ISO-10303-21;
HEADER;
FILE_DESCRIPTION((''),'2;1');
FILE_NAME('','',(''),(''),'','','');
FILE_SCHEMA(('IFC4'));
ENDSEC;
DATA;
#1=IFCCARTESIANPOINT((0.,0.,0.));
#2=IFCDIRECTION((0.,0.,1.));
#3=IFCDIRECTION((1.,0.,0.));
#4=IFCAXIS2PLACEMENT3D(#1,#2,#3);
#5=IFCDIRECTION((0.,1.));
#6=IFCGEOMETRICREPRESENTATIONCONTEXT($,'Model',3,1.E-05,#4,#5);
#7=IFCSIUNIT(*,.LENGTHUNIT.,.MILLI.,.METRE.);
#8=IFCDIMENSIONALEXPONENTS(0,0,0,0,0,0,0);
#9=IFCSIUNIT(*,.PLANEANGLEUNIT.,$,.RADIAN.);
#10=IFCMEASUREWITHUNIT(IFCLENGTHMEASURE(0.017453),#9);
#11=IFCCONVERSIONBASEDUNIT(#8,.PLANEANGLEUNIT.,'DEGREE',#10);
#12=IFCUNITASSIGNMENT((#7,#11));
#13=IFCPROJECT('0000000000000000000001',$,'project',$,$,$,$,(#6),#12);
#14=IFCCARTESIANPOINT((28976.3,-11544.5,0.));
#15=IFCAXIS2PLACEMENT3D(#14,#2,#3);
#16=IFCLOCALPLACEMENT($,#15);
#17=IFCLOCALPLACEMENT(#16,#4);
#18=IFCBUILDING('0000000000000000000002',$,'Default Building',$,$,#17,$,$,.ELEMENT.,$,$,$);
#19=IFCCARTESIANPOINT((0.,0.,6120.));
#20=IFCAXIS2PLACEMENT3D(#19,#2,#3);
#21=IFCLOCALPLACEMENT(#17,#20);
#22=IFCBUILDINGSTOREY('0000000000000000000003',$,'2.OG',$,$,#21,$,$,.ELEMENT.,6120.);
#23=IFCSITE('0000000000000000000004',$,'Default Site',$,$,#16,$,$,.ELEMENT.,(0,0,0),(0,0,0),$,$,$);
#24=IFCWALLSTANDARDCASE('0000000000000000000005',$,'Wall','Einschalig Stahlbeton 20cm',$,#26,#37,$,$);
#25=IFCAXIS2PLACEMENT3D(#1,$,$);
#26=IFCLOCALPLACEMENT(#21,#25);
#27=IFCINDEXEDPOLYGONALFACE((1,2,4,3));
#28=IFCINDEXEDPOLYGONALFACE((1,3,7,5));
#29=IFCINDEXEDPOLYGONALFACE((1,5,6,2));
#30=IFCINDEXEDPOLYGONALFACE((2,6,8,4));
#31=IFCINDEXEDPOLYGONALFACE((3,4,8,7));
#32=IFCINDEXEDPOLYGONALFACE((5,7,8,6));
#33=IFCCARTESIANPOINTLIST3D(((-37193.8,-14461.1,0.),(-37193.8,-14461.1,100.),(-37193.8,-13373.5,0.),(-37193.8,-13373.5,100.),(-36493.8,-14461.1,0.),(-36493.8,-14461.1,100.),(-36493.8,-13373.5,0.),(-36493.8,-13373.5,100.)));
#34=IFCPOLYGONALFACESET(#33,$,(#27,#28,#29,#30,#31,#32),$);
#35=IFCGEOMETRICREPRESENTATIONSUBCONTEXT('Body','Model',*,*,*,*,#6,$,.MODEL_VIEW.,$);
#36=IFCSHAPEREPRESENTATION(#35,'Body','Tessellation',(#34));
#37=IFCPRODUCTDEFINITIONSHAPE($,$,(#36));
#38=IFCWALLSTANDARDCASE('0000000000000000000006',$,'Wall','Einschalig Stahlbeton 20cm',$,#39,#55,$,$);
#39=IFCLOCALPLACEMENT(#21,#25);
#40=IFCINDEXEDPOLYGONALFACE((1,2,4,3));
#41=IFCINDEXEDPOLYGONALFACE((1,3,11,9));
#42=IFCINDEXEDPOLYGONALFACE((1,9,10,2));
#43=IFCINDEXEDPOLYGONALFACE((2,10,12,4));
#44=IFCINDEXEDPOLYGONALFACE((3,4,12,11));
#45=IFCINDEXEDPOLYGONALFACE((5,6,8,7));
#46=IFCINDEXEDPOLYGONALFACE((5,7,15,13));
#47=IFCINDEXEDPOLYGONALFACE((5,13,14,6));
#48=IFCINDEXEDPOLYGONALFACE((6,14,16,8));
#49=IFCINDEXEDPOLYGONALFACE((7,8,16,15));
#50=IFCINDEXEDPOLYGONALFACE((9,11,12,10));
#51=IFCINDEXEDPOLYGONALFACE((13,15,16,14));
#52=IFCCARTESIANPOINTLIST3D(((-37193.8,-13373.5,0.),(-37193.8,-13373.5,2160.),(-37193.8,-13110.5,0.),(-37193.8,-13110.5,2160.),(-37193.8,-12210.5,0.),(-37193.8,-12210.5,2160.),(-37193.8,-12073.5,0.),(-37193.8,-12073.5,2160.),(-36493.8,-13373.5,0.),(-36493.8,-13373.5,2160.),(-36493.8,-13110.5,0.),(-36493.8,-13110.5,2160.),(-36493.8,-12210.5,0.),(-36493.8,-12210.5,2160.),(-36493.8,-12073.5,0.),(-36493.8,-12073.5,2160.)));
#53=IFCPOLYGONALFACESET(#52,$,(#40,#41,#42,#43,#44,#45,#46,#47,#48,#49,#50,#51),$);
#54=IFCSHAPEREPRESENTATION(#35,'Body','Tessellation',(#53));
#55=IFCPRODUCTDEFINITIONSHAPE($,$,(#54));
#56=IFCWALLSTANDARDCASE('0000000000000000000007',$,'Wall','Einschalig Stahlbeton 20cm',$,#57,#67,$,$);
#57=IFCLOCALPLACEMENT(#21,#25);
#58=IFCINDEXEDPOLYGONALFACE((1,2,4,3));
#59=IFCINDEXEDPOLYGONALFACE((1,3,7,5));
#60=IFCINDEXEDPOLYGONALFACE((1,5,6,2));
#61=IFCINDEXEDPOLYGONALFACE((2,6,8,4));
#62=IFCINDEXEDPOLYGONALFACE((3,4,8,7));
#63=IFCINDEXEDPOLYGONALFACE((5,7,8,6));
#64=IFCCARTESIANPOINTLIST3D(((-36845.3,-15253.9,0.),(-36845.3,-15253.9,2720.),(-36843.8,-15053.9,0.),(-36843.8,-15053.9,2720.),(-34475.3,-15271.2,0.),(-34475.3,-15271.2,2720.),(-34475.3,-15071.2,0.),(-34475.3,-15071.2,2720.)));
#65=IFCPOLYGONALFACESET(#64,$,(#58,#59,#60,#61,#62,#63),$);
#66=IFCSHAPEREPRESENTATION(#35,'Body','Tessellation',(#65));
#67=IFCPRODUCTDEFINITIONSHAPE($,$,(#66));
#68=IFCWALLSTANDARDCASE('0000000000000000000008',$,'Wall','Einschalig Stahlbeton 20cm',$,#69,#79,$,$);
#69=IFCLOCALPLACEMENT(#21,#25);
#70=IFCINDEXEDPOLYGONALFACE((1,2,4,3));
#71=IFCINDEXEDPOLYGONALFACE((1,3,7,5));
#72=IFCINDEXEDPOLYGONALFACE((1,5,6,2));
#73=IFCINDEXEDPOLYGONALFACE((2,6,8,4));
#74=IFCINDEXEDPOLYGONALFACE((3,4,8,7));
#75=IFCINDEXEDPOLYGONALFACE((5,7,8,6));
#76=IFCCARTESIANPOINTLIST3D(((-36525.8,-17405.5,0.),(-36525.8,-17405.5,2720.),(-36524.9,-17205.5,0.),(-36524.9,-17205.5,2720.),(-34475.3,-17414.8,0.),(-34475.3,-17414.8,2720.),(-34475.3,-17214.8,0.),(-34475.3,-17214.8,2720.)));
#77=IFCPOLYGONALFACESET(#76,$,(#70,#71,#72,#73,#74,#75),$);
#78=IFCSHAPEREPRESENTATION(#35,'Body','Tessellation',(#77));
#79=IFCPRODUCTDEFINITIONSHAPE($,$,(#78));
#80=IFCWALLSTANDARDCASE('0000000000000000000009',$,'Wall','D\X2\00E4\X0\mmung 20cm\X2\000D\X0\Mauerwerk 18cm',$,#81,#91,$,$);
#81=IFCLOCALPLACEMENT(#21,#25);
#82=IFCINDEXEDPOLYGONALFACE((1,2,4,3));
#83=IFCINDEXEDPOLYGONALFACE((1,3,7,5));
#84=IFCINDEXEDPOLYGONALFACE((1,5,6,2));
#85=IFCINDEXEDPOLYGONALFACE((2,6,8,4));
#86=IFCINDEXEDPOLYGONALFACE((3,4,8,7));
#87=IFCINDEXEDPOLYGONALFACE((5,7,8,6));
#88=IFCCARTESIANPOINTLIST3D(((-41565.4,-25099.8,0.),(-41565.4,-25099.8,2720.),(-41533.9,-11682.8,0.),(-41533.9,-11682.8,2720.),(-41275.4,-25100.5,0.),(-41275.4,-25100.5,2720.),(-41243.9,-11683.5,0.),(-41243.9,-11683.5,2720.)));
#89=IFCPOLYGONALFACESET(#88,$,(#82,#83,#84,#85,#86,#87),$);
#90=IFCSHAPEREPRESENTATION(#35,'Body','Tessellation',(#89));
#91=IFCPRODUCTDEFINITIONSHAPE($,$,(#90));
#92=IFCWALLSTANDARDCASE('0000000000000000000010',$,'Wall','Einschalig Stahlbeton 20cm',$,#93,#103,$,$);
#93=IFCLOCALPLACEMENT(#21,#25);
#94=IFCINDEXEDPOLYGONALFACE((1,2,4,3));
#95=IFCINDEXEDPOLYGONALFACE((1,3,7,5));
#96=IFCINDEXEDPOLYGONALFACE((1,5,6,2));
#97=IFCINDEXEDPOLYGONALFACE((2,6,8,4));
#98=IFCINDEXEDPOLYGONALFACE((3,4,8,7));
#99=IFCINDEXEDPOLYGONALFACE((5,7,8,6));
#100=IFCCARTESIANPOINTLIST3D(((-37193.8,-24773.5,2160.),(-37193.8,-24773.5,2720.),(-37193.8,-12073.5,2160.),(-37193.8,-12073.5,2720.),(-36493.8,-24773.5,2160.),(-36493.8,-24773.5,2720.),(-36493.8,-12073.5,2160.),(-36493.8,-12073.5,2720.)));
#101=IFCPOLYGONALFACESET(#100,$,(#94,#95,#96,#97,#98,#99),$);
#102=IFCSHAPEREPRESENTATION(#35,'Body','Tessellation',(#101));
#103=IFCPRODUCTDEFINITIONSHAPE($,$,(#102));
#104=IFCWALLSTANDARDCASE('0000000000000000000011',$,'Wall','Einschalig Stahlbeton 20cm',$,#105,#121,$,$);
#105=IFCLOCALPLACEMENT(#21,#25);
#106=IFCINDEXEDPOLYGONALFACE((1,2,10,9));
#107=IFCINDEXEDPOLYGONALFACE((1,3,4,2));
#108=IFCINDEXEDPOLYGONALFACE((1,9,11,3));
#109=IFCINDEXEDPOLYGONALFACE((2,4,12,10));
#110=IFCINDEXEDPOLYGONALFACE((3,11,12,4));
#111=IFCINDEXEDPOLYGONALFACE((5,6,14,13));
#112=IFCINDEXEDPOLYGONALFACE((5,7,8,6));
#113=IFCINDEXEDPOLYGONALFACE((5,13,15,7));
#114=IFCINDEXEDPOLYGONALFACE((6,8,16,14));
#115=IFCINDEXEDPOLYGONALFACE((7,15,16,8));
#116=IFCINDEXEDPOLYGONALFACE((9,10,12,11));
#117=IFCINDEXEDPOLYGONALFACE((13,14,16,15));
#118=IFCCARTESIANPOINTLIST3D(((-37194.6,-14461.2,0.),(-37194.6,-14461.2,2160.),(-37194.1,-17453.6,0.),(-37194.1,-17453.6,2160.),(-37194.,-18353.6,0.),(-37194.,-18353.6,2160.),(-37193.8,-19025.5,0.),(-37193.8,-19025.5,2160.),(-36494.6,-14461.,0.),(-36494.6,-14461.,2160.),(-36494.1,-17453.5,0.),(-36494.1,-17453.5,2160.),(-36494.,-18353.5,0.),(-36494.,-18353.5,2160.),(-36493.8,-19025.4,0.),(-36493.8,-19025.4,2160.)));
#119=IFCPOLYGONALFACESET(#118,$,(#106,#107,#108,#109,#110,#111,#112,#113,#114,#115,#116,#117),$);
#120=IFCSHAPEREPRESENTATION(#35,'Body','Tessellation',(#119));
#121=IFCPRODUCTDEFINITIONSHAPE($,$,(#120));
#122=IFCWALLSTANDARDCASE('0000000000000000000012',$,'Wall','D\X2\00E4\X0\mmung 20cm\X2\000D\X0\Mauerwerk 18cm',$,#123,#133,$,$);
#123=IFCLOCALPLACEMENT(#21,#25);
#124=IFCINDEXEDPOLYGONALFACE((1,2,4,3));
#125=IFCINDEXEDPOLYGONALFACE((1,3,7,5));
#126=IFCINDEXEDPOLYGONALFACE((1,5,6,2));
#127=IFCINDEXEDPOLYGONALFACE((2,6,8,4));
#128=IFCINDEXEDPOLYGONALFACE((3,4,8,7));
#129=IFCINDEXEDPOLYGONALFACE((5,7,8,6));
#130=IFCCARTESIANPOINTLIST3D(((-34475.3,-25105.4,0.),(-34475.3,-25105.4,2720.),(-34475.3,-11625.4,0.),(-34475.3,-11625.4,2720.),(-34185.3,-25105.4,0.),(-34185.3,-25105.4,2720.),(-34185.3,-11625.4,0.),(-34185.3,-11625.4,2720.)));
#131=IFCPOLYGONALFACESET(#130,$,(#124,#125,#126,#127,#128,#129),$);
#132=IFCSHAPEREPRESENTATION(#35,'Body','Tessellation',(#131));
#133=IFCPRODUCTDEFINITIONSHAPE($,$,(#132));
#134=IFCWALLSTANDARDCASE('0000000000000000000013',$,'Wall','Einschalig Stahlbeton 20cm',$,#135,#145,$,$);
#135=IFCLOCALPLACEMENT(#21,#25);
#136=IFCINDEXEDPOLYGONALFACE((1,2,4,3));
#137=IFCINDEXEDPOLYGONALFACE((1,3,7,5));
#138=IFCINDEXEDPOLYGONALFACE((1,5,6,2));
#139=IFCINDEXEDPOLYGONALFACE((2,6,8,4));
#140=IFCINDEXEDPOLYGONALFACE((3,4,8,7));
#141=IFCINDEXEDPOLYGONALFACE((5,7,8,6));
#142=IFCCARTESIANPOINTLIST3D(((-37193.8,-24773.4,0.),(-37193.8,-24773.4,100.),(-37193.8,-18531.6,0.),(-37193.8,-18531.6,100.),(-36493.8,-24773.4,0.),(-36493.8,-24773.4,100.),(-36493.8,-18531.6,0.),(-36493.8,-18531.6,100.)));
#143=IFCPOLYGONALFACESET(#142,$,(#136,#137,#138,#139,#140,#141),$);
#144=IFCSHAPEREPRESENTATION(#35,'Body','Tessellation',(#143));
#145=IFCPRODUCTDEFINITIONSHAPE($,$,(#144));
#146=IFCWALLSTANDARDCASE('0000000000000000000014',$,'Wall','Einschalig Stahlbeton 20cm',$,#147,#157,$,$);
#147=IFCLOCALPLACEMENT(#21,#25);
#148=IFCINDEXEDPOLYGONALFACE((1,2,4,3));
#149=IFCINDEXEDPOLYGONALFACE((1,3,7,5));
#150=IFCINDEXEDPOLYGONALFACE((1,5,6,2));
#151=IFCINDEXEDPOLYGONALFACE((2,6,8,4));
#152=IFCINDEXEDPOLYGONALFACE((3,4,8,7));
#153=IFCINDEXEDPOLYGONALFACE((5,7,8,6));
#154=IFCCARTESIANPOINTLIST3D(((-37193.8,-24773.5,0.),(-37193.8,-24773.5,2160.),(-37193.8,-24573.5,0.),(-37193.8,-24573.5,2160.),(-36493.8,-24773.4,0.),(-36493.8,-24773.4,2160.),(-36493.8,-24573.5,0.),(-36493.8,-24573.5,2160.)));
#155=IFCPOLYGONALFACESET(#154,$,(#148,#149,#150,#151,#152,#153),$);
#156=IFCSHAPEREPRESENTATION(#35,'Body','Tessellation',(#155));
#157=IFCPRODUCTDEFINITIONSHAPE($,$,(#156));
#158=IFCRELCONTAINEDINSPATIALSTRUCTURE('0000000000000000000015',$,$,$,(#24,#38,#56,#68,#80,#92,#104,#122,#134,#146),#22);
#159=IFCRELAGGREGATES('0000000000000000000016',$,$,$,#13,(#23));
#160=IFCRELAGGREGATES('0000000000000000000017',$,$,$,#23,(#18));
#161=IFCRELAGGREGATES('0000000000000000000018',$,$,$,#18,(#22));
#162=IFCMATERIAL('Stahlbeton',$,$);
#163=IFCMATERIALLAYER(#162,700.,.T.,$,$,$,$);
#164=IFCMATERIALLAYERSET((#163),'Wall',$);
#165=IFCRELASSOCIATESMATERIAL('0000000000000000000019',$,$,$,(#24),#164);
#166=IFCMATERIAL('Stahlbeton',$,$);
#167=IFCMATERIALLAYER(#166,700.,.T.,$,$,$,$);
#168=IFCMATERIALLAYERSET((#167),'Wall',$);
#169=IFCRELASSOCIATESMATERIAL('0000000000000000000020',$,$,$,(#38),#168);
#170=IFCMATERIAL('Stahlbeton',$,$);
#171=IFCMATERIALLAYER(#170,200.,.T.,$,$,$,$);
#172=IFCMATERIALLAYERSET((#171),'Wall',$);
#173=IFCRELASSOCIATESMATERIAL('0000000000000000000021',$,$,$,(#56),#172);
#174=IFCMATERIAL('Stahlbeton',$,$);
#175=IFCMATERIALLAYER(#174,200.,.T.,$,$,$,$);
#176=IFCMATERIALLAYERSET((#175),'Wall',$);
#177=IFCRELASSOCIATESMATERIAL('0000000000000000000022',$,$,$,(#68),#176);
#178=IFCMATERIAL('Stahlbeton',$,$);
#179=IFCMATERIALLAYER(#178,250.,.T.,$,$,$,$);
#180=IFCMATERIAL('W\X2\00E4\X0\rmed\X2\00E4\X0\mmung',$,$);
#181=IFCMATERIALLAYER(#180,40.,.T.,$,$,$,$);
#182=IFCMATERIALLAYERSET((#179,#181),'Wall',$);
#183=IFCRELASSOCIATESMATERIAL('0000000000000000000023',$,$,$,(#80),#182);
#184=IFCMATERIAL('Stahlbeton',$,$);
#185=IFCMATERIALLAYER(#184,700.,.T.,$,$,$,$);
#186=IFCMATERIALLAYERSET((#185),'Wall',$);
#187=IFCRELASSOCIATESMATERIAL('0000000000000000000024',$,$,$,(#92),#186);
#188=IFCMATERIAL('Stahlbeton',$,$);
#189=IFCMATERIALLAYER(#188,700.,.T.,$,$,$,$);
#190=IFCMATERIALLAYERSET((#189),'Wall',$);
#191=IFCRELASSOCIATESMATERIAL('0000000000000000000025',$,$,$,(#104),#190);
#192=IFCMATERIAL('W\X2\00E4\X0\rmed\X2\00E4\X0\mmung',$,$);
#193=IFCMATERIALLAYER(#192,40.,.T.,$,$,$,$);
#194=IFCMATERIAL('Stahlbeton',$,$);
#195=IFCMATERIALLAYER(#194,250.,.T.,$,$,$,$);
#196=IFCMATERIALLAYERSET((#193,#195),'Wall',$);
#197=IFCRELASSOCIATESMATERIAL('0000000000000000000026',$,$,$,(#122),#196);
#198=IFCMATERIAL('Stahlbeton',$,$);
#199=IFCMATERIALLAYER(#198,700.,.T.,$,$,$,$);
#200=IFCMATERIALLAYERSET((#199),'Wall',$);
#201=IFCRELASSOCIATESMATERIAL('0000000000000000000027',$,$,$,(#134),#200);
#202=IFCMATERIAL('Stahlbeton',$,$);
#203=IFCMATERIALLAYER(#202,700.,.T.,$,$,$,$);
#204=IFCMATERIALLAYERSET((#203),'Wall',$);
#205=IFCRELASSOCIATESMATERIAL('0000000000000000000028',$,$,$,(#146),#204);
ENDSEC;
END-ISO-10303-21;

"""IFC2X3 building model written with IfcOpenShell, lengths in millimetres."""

from ifc_helpers import new_model, entity, si_unit, converted_unit, direction, frame, origin_with_axes, place, context, subcontext, project, spatial, polyline, outline, extrude, material, layer, layer_set, layer_usage, element, save


model = new_model("IFC2X3")

# Units and contexts
model_context = context("Model", 3, precision=1e-05, world=origin_with_axes(), true_north=direction((0.0, 1.0)))
body_context = subcontext(model_context, "Body", "Model", "MODEL_VIEW")
ifc_project = project(units=[si_unit("LENGTHUNIT", "METRE", prefix="MILLI"), converted_unit("PLANEANGLEUNIT", "DEGREE", entity("IfcLengthMeasure", 0.017453), si_unit("PLANEANGLEUNIT", "RADIAN"), dimensions=[0, 0, 0, 0, 0, 0, 0])], contexts=[model_context])

# Site, building, storey
site_placement = place(None, frame((28976.3, -11544.5, 0.0), z_axis=(0.0, 0.0, 1.0), x_axis=(1.0, 0.0, 0.0)))
site = spatial("IfcSite", under=ifc_project, at=site_placement, Name="Default Site", CompositionType="ELEMENT", RefLatitude=(0, 0, 0), RefLongitude=(0, 0, 0))
building_placement = place(site_placement, origin_with_axes())
building = spatial("IfcBuilding", under=site, at=building_placement, Name="Default Building", CompositionType="ELEMENT")
storey_placement = place(building_placement, frame((0.0, 0.0, 6120.0), z_axis=(0.0, 0.0, 1.0), x_axis=(1.0, 0.0, 0.0)))
storey = spatial("IfcBuildingStorey", under=building, at=storey_placement, Name="2.OG", CompositionType="ELEMENT", Elevation=6120.0)

# Wall
ifc_material_1 = material(Name="Stahlbeton")
ifc_layer_1 = layer(ifc_material_1, 700.0, ventilated=True)
ifc_layer_set_1 = layer_set([ifc_layer_1], Name="Wall")
ifc_layer_usage_1 = layer_usage(ifc_layer_set_1, "AXIS2", "POSITIVE", -350.0)
wall_1_placement = place(storey_placement, frame((-36843.8, -13373.5, 0.0), z_axis=(0.0, 0.0, 1.0), x_axis=(0.0, -1.0, 0.0)))
element("IfcWallStandardCase", 1, at=wall_1_placement, inside=storey, material=ifc_layer_usage_1, Name="Wall", Description="Einschalig Stahlbeton 20cm", context=body_context, shape_type="SweptSolid", body=[
    extrude(outline(polyline([(0.0, -350.0), (0.0, 350.0), (1087.7, 350.0), (1087.7, -350.0), (0.0, -350.0)])), origin_with_axes(), (0.0, 0.0, 1.0), 100.0),
])

# Wall, opening
ifc_material_2 = material(Name="Stahlbeton")
ifc_layer_2 = layer(ifc_material_2, 700.0, ventilated=True)
ifc_layer_set_2 = layer_set([ifc_layer_2], Name="Wall")
ifc_layer_usage_2 = layer_usage(ifc_layer_set_2, "AXIS2", "POSITIVE", -350.0)
wall_2_placement = place(storey_placement, frame((-36843.8, -13373.5, 0.0), z_axis=(0.0, 0.0, 1.0), x_axis=(0.0, 1.0, 0.0)))
wall_2 = element("IfcWallStandardCase", 2, at=wall_2_placement, inside=storey, material=ifc_layer_usage_2, Name="Wall", Description="Einschalig Stahlbeton 20cm", context=body_context, shape_type="SweptSolid", body=[
    extrude(outline(polyline([(0.0, -350.0), (0.0, 350.0), (1300.0, 350.0), (1300.0, -350.0), (0.0, -350.0)])), origin_with_axes(), (0.0, 0.0, 1.0), 2160.0),
])
opening_1_placement = place(wall_2_placement, frame((1163.0, 0.0, 0.0), z_axis=(0.0, -1.0, 0.0), x_axis=(0.0, 0.0, 1.0)))
element("IfcOpeningElement", 3, at=opening_1_placement, cuts=wall_2, context=body_context, shape_type="SweptSolid", body=[
    extrude(outline(polyline([(0.0, 0.0), (2160.0, 0.0), (2160.0, 900.0), (0.0, 900.0), (0.0, 0.0), (0.0, 0.0)])), frame((0.0, 0.0, 700.0), z_axis=(0.0, 0.0, 1.0), x_axis=(1.0, 0.0, 0.0)), (0.0, 0.0, -1.0), 1400.0),
])

# Walls
ifc_material_3 = material(Name="Stahlbeton")
ifc_layer_3 = layer(ifc_material_3, 200.0, ventilated=True)
ifc_layer_set_3 = layer_set([ifc_layer_3], Name="Wall")
ifc_layer_usage_3 = layer_usage(ifc_layer_set_3, "AXIS2", "POSITIVE", -100.0)
wall_3_placement = place(storey_placement, frame((-36844.5, -15153.9, 0.0), z_axis=(0.0, 0.0, 1.0), x_axis=(0.999973, -0.007317, 0.0)))
element("IfcWallStandardCase", 4, at=wall_3_placement, inside=storey, material=ifc_layer_usage_3, Name="Wall", Description="Einschalig Stahlbeton 20cm", context=body_context, shape_type="SweptSolid", body=[
    extrude(outline(polyline([(2370.0, -100.0), (2368.5, 100.0), (0.0, 100.0), (0.0, -100.0), (2370.0, -100.0)])), origin_with_axes(), (0.0, 0.0, 1.0), 2720.0),
])
ifc_material_4 = material(Name="Stahlbeton")
ifc_layer_4 = layer(ifc_material_4, 200.0, ventilated=True)
ifc_layer_set_4 = layer_set([ifc_layer_4], Name="Wall")
ifc_layer_usage_4 = layer_usage(ifc_layer_set_4, "AXIS2", "POSITIVE", -100.0)
wall_4_placement = place(storey_placement, frame((-36525.4, -17305.5, 0.0), z_axis=(0.0, 0.0, 1.0), x_axis=(0.99999, -0.004536, 0.0)))
element("IfcWallStandardCase", 5, at=wall_4_placement, inside=storey, material=ifc_layer_usage_4, Name="Wall", Description="Einschalig Stahlbeton 20cm", context=body_context, shape_type="SweptSolid", body=[
    extrude(outline(polyline([(2050.5, -100.0), (2049.6, 100.0), (0.0, 100.0), (0.0, -100.0), (2050.5, -100.0)])), origin_with_axes(), (0.0, 0.0, 1.0), 2720.0),
])
ifc_material_5 = material(Name="Stahlbeton")
ifc_layer_5 = layer(ifc_material_5, 250.0, ventilated=True)
ifc_material_6 = material(Name="Wärmedämmung")
ifc_layer_6 = layer(ifc_material_6, 40.0, ventilated=True)
ifc_layer_set_5 = layer_set([ifc_layer_5, ifc_layer_6], Name="Wall")
ifc_layer_usage_5 = layer_usage(ifc_layer_set_5, "AXIS2", "POSITIVE", -145.0)
wall_5_placement = place(storey_placement, frame((-41420.4, -25100.1, 0.0), z_axis=(0.0, 0.0, 1.0), x_axis=(0.002348, 0.999997, 0.0)))
element("IfcWallStandardCase", 6, at=wall_5_placement, inside=storey, material=ifc_layer_usage_5, Name="Wall", Description="Dämmung 20cm\rMauerwerk 18cm", context=body_context, shape_type="SweptSolid", body=[
    extrude(outline(polyline([(0.0, -145.0), (0.0, 145.0), (13417.0, 145.0), (13417.0, -145.0), (0.0, -145.0)])), origin_with_axes(), (0.0, 0.0, 1.0), 2720.0),
])

# Walls, openings
ifc_material_7 = material(Name="Stahlbeton")
ifc_layer_7 = layer(ifc_material_7, 700.0, ventilated=True)
ifc_layer_set_6 = layer_set([ifc_layer_7], Name="Wall")
ifc_layer_usage_6 = layer_usage(ifc_layer_set_6, "AXIS2", "POSITIVE", -350.0)
wall_6_placement = place(storey_placement, frame((-36843.8, -12073.5, 2160.0), z_axis=(0.0, 0.0, 1.0), x_axis=(0.0, -1.0, 0.0)))
wall_6 = element("IfcWallStandardCase", 7, at=wall_6_placement, inside=storey, material=ifc_layer_usage_6, Name="Wall", Description="Einschalig Stahlbeton 20cm", context=body_context, shape_type="SweptSolid", body=[
    extrude(outline(polyline([(0.0, -350.0), (0.0, 350.0), (12700.0, 350.0), (12700.0, -350.0), (0.0, -350.0)])), origin_with_axes(), (0.0, 0.0, 1.0), 560.0),
])
opening_2_placement = place(wall_6_placement, frame((4232.1, 0.0, -2160.0), z_axis=(0.0, 1.0, 0.0), x_axis=(0.0, 0.0, 1.0)))
element("IfcOpeningElement", 8, at=opening_2_placement, cuts=wall_6, context=body_context, shape_type="SweptSolid", body=[
    extrude(outline(polyline([(0.0, 0.0), (2160.0, 0.0), (2160.0, 900.0), (0.0, 900.0), (0.0, 0.0), (0.0, 0.0)])), frame((0.0, 0.0, 700.0), z_axis=(0.0, 0.0, 1.0), x_axis=(1.0, 0.0, 0.0)), (0.0, 0.0, -1.0), 1400.0),
])
ifc_material_8 = material(Name="Stahlbeton")
ifc_layer_8 = layer(ifc_material_8, 700.0, ventilated=True)
ifc_layer_set_7 = layer_set([ifc_layer_8], Name="Wall")
ifc_layer_usage_7 = layer_usage(ifc_layer_set_7, "AXIS2", "POSITIVE", -350.0)
wall_7_placement = place(storey_placement, frame((-36843.8, -19025.4, 0.0), z_axis=(0.0, 0.0, 1.0), x_axis=(-0.000176, 1.0, 0.0)))
wall_7 = element("IfcWallStandardCase", 9, at=wall_7_placement, inside=storey, material=ifc_layer_usage_7, Name="Wall", Description="Einschalig Stahlbeton 20cm", context=body_context, shape_type="SweptSolid", body=[
    extrude(outline(polyline([(0.0, -350.0), (0.0, 350.0), (4564.3, 350.0), (4564.3, -350.0), (0.0, -350.0)])), origin_with_axes(), (0.0, 0.0, 1.0), 2160.0),
])
opening_3_placement = place(wall_7_placement, frame((671.9, 0.0, 0.0), z_axis=(0.0, 1.0, 0.0), x_axis=(0.0, 0.0, 1.0)))
element("IfcOpeningElement", 10, at=opening_3_placement, cuts=wall_7, context=body_context, shape_type="SweptSolid", body=[
    extrude(outline(polyline([(0.0, 0.0), (2160.0, 0.0), (2160.0, 900.0), (0.0, 900.0), (0.0, 0.0), (0.0, 0.0)])), frame((0.0, 0.0, 700.0), z_axis=(0.0, 0.0, 1.0), x_axis=(1.0, 0.0, 0.0)), (0.0, 0.0, -1.0), 1400.0),
])

# Walls
ifc_material_9 = material(Name="Wärmedämmung")
ifc_layer_9 = layer(ifc_material_9, 40.0, ventilated=True)
ifc_material_10 = material(Name="Stahlbeton")
ifc_layer_10 = layer(ifc_material_10, 250.0, ventilated=True)
ifc_layer_set_8 = layer_set([ifc_layer_9, ifc_layer_10], Name="Wall")
ifc_layer_usage_8 = layer_usage(ifc_layer_set_8, "AXIS2", "POSITIVE", -145.0)
wall_8_placement = place(storey_placement, frame((-34330.3, -11625.4, 0.0), z_axis=(0.0, 0.0, 1.0), x_axis=(0.0, -1.0, 0.0)))
element("IfcWallStandardCase", 11, at=wall_8_placement, inside=storey, material=ifc_layer_usage_8, Name="Wall", Description="Dämmung 20cm\rMauerwerk 18cm", context=body_context, shape_type="SweptSolid", body=[
    extrude(outline(polyline([(0.0, -145.0), (0.0, 145.0), (13480.0, 145.0), (13480.0, -145.0), (0.0, -145.0)])), origin_with_axes(), (0.0, 0.0, 1.0), 2720.0),
])
ifc_material_11 = material(Name="Stahlbeton")
ifc_layer_11 = layer(ifc_material_11, 700.0, ventilated=True)
ifc_layer_set_9 = layer_set([ifc_layer_11], Name="Wall")
ifc_layer_usage_9 = layer_usage(ifc_layer_set_9, "AXIS2", "POSITIVE", -350.0)
wall_9_placement = place(storey_placement, frame((-36843.8, -24773.4, 0.0), z_axis=(0.0, 0.0, 1.0), x_axis=(0.0, 1.0, 0.0)))
element("IfcWallStandardCase", 12, at=wall_9_placement, inside=storey, material=ifc_layer_usage_9, Name="Wall", Description="Einschalig Stahlbeton 20cm", context=body_context, shape_type="SweptSolid", body=[
    extrude(outline(polyline([(0.0, -350.0), (0.0, 350.0), (6241.8, 350.0), (6241.8, -350.0), (0.0, -350.0)])), origin_with_axes(), (0.0, 0.0, 1.0), 100.0),
])
ifc_material_12 = material(Name="Stahlbeton")
ifc_layer_12 = layer(ifc_material_12, 700.0, ventilated=True)
ifc_layer_set_10 = layer_set([ifc_layer_12], Name="Wall")
ifc_layer_usage_10 = layer_usage(ifc_layer_set_10, "AXIS2", "POSITIVE", -350.0)
wall_10_placement = place(storey_placement, frame((-36843.8, -24773.5, 0.0), z_axis=(0.0, 0.0, 1.0), x_axis=(-0.000019, 1.0, 0.0)))
element("IfcWallStandardCase", 13, at=wall_10_placement, inside=storey, material=ifc_layer_usage_10, Name="Wall", Description="Einschalig Stahlbeton 20cm", context=body_context, shape_type="SweptSolid", body=[
    extrude(outline(polyline([(0.0, 350.0), (0.0, -350.0), (200.0, -350.0), (200.0, 350.0), (0.0, 350.0)])), origin_with_axes(), (0.0, 0.0, 1.0), 2160.0),
])

save(model, "model.ifc")
